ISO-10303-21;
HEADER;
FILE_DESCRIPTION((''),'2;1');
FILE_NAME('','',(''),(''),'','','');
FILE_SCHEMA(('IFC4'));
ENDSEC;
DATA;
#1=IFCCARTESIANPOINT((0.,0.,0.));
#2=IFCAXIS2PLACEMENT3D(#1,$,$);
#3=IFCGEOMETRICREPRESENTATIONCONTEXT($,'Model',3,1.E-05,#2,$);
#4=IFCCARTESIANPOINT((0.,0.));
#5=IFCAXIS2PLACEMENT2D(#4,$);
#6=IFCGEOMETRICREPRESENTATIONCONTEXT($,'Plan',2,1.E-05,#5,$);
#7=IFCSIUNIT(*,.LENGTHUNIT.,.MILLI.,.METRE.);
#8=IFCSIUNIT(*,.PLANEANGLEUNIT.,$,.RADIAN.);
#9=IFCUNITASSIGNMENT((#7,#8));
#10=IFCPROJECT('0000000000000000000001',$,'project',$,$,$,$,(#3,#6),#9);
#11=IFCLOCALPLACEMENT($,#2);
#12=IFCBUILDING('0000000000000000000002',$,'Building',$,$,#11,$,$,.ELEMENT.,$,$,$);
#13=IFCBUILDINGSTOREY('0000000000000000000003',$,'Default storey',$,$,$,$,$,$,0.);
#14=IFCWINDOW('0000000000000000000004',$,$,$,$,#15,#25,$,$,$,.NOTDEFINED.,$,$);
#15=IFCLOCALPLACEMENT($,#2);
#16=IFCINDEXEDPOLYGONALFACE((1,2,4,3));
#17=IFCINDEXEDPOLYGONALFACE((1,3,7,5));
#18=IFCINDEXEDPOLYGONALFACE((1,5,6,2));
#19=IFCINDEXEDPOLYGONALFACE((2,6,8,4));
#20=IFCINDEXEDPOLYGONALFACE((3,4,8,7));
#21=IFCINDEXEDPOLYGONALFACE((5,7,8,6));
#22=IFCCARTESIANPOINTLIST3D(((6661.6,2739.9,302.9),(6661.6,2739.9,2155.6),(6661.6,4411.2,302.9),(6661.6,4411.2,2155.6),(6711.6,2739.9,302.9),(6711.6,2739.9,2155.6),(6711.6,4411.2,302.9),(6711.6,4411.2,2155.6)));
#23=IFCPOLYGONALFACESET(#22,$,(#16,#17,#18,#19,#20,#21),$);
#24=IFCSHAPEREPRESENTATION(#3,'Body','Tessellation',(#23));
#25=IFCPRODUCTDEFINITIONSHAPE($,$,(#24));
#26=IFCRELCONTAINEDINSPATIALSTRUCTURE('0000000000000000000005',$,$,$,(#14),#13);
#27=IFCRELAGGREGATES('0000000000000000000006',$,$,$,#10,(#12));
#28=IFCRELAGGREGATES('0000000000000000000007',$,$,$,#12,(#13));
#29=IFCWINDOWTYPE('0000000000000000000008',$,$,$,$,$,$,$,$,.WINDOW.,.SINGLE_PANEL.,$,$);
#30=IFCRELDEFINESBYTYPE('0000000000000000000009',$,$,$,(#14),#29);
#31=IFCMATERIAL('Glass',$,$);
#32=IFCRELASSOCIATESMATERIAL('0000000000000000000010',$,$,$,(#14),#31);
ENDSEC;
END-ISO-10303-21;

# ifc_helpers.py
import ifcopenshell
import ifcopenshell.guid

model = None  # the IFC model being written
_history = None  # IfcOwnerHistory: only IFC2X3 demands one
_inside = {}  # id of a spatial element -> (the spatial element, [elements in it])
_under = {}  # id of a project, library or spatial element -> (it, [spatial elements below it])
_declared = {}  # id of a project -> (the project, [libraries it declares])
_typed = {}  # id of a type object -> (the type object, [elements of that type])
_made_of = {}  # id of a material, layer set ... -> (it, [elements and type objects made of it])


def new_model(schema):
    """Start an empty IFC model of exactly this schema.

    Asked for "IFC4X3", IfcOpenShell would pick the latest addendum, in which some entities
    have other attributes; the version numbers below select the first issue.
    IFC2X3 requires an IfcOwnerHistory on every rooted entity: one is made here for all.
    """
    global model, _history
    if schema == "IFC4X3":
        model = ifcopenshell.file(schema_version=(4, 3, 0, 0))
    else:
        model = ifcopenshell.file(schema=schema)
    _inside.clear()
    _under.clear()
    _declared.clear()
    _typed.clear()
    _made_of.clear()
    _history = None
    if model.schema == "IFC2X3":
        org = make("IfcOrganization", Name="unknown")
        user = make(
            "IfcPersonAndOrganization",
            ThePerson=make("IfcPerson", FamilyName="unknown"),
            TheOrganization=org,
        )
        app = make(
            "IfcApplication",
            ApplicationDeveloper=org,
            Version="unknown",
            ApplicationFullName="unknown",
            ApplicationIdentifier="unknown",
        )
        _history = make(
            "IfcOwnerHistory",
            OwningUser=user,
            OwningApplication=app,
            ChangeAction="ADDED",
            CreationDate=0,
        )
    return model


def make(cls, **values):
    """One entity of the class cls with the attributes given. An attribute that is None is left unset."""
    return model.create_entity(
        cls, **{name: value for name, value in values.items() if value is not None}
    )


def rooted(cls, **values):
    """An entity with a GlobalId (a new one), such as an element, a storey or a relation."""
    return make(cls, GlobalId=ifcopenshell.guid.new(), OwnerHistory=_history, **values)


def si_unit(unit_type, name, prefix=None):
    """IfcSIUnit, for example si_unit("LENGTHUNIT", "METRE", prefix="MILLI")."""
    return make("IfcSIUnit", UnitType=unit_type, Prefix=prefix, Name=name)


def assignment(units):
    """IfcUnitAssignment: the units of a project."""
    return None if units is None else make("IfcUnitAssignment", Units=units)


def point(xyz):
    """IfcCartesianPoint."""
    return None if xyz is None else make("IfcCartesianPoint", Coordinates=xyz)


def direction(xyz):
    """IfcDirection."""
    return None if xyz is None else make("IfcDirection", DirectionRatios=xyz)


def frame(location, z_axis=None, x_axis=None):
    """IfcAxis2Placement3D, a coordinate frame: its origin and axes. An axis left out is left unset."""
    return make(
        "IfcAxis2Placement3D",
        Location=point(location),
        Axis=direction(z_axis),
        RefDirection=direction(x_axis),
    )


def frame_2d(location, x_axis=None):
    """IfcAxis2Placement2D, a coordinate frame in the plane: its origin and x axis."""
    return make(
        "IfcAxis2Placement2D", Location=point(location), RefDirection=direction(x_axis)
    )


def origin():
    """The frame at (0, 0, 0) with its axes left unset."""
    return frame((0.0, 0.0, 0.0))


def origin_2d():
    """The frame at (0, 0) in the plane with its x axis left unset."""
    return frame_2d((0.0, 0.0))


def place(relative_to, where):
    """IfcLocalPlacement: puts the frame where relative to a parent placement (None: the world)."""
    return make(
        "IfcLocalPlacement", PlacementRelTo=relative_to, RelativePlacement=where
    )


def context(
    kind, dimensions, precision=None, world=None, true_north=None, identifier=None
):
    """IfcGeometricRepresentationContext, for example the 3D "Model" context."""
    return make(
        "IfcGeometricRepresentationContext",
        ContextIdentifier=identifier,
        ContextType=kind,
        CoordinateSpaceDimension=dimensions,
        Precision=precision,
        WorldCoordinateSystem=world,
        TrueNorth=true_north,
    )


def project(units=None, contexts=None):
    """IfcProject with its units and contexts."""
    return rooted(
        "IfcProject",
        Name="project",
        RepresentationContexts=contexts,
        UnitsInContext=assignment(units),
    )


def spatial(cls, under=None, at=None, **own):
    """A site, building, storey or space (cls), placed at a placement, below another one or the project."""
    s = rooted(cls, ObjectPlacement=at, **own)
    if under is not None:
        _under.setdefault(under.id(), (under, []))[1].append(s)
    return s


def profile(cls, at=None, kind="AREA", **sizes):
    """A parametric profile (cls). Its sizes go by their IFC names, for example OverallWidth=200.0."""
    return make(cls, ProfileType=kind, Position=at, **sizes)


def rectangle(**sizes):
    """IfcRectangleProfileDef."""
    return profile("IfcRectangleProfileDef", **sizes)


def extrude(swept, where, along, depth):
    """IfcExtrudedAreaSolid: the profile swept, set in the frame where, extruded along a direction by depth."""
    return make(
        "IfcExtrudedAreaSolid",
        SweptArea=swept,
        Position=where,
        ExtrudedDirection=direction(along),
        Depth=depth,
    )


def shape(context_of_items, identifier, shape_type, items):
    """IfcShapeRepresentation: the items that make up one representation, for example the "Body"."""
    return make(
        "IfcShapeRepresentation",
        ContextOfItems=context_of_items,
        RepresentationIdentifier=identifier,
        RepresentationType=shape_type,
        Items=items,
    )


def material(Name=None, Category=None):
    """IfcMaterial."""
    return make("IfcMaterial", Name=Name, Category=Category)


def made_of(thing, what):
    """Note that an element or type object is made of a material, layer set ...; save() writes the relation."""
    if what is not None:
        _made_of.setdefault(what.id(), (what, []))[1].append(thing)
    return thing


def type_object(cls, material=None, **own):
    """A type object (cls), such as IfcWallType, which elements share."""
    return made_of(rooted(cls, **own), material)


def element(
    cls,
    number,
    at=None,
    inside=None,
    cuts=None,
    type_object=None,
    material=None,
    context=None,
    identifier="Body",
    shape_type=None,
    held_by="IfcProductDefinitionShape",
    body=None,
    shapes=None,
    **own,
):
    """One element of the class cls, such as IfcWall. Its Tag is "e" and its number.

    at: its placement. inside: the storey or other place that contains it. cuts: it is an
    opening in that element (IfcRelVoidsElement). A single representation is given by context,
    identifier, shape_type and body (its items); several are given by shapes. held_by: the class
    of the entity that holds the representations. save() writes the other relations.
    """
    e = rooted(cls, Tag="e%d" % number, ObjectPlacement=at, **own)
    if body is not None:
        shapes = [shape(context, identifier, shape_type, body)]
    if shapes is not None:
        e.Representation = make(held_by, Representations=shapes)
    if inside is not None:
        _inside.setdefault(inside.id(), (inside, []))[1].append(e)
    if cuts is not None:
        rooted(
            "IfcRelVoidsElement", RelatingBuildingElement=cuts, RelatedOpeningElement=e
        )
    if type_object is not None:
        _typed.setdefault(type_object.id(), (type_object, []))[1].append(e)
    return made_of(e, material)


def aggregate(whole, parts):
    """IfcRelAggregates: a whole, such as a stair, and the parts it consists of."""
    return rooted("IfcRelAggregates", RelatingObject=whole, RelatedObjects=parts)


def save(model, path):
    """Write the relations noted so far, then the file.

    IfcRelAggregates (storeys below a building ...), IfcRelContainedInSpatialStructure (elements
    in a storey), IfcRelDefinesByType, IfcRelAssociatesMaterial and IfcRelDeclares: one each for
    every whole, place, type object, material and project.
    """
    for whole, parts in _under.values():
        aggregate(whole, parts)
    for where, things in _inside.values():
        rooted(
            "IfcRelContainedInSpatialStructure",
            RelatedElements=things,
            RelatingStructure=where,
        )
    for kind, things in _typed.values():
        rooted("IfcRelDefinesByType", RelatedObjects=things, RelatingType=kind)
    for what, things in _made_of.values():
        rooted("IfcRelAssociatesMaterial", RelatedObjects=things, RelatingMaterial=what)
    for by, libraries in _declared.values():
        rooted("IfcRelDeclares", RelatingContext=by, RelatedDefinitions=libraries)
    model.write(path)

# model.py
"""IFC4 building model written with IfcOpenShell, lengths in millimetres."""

from ifc_helpers import new_model, si_unit, frame, origin, origin_2d, place, context, project, spatial, rectangle, extrude, material, type_object, element, save


model = new_model("IFC4")

# Units and contexts
model_context = context("Model", 3, precision=1e-05, world=origin())
plan_context = context("Plan", 2, precision=1e-05, world=origin_2d())
ifc_project = project(units=[si_unit("LENGTHUNIT", "METRE", prefix="MILLI"), si_unit("PLANEANGLEUNIT", "RADIAN")], contexts=[model_context, plan_context])

# Building, storey
placement = place(None, origin())
building = spatial("IfcBuilding", under=ifc_project, at=placement, Name="Building", CompositionType="ELEMENT")
storey = spatial("IfcBuildingStorey", under=building, Name="Default storey", Elevation=0.0)

# Window
window_type_1 = type_object("IfcWindowType", PartitioningType="SINGLE_PANEL", PredefinedType="WINDOW")
ifc_material_1 = material(Name="Glass")
element("IfcWindow", 1, at=placement, inside=storey, type_object=window_type_1, material=ifc_material_1, PredefinedType="NOTDEFINED", context=model_context, shape_type="CSG", body=[
    extrude(rectangle(XDim=1671.3, YDim=50.0, at=origin_2d()), frame((6686.6, 3575.5, 302.9), z_axis=(0.0, 0.0, 1000.0), x_axis=(0.0, 1671.339989, 0.0)), (0.0, 0.0, 1.0), 1852.8),
])

save(model, "model.ifc")
